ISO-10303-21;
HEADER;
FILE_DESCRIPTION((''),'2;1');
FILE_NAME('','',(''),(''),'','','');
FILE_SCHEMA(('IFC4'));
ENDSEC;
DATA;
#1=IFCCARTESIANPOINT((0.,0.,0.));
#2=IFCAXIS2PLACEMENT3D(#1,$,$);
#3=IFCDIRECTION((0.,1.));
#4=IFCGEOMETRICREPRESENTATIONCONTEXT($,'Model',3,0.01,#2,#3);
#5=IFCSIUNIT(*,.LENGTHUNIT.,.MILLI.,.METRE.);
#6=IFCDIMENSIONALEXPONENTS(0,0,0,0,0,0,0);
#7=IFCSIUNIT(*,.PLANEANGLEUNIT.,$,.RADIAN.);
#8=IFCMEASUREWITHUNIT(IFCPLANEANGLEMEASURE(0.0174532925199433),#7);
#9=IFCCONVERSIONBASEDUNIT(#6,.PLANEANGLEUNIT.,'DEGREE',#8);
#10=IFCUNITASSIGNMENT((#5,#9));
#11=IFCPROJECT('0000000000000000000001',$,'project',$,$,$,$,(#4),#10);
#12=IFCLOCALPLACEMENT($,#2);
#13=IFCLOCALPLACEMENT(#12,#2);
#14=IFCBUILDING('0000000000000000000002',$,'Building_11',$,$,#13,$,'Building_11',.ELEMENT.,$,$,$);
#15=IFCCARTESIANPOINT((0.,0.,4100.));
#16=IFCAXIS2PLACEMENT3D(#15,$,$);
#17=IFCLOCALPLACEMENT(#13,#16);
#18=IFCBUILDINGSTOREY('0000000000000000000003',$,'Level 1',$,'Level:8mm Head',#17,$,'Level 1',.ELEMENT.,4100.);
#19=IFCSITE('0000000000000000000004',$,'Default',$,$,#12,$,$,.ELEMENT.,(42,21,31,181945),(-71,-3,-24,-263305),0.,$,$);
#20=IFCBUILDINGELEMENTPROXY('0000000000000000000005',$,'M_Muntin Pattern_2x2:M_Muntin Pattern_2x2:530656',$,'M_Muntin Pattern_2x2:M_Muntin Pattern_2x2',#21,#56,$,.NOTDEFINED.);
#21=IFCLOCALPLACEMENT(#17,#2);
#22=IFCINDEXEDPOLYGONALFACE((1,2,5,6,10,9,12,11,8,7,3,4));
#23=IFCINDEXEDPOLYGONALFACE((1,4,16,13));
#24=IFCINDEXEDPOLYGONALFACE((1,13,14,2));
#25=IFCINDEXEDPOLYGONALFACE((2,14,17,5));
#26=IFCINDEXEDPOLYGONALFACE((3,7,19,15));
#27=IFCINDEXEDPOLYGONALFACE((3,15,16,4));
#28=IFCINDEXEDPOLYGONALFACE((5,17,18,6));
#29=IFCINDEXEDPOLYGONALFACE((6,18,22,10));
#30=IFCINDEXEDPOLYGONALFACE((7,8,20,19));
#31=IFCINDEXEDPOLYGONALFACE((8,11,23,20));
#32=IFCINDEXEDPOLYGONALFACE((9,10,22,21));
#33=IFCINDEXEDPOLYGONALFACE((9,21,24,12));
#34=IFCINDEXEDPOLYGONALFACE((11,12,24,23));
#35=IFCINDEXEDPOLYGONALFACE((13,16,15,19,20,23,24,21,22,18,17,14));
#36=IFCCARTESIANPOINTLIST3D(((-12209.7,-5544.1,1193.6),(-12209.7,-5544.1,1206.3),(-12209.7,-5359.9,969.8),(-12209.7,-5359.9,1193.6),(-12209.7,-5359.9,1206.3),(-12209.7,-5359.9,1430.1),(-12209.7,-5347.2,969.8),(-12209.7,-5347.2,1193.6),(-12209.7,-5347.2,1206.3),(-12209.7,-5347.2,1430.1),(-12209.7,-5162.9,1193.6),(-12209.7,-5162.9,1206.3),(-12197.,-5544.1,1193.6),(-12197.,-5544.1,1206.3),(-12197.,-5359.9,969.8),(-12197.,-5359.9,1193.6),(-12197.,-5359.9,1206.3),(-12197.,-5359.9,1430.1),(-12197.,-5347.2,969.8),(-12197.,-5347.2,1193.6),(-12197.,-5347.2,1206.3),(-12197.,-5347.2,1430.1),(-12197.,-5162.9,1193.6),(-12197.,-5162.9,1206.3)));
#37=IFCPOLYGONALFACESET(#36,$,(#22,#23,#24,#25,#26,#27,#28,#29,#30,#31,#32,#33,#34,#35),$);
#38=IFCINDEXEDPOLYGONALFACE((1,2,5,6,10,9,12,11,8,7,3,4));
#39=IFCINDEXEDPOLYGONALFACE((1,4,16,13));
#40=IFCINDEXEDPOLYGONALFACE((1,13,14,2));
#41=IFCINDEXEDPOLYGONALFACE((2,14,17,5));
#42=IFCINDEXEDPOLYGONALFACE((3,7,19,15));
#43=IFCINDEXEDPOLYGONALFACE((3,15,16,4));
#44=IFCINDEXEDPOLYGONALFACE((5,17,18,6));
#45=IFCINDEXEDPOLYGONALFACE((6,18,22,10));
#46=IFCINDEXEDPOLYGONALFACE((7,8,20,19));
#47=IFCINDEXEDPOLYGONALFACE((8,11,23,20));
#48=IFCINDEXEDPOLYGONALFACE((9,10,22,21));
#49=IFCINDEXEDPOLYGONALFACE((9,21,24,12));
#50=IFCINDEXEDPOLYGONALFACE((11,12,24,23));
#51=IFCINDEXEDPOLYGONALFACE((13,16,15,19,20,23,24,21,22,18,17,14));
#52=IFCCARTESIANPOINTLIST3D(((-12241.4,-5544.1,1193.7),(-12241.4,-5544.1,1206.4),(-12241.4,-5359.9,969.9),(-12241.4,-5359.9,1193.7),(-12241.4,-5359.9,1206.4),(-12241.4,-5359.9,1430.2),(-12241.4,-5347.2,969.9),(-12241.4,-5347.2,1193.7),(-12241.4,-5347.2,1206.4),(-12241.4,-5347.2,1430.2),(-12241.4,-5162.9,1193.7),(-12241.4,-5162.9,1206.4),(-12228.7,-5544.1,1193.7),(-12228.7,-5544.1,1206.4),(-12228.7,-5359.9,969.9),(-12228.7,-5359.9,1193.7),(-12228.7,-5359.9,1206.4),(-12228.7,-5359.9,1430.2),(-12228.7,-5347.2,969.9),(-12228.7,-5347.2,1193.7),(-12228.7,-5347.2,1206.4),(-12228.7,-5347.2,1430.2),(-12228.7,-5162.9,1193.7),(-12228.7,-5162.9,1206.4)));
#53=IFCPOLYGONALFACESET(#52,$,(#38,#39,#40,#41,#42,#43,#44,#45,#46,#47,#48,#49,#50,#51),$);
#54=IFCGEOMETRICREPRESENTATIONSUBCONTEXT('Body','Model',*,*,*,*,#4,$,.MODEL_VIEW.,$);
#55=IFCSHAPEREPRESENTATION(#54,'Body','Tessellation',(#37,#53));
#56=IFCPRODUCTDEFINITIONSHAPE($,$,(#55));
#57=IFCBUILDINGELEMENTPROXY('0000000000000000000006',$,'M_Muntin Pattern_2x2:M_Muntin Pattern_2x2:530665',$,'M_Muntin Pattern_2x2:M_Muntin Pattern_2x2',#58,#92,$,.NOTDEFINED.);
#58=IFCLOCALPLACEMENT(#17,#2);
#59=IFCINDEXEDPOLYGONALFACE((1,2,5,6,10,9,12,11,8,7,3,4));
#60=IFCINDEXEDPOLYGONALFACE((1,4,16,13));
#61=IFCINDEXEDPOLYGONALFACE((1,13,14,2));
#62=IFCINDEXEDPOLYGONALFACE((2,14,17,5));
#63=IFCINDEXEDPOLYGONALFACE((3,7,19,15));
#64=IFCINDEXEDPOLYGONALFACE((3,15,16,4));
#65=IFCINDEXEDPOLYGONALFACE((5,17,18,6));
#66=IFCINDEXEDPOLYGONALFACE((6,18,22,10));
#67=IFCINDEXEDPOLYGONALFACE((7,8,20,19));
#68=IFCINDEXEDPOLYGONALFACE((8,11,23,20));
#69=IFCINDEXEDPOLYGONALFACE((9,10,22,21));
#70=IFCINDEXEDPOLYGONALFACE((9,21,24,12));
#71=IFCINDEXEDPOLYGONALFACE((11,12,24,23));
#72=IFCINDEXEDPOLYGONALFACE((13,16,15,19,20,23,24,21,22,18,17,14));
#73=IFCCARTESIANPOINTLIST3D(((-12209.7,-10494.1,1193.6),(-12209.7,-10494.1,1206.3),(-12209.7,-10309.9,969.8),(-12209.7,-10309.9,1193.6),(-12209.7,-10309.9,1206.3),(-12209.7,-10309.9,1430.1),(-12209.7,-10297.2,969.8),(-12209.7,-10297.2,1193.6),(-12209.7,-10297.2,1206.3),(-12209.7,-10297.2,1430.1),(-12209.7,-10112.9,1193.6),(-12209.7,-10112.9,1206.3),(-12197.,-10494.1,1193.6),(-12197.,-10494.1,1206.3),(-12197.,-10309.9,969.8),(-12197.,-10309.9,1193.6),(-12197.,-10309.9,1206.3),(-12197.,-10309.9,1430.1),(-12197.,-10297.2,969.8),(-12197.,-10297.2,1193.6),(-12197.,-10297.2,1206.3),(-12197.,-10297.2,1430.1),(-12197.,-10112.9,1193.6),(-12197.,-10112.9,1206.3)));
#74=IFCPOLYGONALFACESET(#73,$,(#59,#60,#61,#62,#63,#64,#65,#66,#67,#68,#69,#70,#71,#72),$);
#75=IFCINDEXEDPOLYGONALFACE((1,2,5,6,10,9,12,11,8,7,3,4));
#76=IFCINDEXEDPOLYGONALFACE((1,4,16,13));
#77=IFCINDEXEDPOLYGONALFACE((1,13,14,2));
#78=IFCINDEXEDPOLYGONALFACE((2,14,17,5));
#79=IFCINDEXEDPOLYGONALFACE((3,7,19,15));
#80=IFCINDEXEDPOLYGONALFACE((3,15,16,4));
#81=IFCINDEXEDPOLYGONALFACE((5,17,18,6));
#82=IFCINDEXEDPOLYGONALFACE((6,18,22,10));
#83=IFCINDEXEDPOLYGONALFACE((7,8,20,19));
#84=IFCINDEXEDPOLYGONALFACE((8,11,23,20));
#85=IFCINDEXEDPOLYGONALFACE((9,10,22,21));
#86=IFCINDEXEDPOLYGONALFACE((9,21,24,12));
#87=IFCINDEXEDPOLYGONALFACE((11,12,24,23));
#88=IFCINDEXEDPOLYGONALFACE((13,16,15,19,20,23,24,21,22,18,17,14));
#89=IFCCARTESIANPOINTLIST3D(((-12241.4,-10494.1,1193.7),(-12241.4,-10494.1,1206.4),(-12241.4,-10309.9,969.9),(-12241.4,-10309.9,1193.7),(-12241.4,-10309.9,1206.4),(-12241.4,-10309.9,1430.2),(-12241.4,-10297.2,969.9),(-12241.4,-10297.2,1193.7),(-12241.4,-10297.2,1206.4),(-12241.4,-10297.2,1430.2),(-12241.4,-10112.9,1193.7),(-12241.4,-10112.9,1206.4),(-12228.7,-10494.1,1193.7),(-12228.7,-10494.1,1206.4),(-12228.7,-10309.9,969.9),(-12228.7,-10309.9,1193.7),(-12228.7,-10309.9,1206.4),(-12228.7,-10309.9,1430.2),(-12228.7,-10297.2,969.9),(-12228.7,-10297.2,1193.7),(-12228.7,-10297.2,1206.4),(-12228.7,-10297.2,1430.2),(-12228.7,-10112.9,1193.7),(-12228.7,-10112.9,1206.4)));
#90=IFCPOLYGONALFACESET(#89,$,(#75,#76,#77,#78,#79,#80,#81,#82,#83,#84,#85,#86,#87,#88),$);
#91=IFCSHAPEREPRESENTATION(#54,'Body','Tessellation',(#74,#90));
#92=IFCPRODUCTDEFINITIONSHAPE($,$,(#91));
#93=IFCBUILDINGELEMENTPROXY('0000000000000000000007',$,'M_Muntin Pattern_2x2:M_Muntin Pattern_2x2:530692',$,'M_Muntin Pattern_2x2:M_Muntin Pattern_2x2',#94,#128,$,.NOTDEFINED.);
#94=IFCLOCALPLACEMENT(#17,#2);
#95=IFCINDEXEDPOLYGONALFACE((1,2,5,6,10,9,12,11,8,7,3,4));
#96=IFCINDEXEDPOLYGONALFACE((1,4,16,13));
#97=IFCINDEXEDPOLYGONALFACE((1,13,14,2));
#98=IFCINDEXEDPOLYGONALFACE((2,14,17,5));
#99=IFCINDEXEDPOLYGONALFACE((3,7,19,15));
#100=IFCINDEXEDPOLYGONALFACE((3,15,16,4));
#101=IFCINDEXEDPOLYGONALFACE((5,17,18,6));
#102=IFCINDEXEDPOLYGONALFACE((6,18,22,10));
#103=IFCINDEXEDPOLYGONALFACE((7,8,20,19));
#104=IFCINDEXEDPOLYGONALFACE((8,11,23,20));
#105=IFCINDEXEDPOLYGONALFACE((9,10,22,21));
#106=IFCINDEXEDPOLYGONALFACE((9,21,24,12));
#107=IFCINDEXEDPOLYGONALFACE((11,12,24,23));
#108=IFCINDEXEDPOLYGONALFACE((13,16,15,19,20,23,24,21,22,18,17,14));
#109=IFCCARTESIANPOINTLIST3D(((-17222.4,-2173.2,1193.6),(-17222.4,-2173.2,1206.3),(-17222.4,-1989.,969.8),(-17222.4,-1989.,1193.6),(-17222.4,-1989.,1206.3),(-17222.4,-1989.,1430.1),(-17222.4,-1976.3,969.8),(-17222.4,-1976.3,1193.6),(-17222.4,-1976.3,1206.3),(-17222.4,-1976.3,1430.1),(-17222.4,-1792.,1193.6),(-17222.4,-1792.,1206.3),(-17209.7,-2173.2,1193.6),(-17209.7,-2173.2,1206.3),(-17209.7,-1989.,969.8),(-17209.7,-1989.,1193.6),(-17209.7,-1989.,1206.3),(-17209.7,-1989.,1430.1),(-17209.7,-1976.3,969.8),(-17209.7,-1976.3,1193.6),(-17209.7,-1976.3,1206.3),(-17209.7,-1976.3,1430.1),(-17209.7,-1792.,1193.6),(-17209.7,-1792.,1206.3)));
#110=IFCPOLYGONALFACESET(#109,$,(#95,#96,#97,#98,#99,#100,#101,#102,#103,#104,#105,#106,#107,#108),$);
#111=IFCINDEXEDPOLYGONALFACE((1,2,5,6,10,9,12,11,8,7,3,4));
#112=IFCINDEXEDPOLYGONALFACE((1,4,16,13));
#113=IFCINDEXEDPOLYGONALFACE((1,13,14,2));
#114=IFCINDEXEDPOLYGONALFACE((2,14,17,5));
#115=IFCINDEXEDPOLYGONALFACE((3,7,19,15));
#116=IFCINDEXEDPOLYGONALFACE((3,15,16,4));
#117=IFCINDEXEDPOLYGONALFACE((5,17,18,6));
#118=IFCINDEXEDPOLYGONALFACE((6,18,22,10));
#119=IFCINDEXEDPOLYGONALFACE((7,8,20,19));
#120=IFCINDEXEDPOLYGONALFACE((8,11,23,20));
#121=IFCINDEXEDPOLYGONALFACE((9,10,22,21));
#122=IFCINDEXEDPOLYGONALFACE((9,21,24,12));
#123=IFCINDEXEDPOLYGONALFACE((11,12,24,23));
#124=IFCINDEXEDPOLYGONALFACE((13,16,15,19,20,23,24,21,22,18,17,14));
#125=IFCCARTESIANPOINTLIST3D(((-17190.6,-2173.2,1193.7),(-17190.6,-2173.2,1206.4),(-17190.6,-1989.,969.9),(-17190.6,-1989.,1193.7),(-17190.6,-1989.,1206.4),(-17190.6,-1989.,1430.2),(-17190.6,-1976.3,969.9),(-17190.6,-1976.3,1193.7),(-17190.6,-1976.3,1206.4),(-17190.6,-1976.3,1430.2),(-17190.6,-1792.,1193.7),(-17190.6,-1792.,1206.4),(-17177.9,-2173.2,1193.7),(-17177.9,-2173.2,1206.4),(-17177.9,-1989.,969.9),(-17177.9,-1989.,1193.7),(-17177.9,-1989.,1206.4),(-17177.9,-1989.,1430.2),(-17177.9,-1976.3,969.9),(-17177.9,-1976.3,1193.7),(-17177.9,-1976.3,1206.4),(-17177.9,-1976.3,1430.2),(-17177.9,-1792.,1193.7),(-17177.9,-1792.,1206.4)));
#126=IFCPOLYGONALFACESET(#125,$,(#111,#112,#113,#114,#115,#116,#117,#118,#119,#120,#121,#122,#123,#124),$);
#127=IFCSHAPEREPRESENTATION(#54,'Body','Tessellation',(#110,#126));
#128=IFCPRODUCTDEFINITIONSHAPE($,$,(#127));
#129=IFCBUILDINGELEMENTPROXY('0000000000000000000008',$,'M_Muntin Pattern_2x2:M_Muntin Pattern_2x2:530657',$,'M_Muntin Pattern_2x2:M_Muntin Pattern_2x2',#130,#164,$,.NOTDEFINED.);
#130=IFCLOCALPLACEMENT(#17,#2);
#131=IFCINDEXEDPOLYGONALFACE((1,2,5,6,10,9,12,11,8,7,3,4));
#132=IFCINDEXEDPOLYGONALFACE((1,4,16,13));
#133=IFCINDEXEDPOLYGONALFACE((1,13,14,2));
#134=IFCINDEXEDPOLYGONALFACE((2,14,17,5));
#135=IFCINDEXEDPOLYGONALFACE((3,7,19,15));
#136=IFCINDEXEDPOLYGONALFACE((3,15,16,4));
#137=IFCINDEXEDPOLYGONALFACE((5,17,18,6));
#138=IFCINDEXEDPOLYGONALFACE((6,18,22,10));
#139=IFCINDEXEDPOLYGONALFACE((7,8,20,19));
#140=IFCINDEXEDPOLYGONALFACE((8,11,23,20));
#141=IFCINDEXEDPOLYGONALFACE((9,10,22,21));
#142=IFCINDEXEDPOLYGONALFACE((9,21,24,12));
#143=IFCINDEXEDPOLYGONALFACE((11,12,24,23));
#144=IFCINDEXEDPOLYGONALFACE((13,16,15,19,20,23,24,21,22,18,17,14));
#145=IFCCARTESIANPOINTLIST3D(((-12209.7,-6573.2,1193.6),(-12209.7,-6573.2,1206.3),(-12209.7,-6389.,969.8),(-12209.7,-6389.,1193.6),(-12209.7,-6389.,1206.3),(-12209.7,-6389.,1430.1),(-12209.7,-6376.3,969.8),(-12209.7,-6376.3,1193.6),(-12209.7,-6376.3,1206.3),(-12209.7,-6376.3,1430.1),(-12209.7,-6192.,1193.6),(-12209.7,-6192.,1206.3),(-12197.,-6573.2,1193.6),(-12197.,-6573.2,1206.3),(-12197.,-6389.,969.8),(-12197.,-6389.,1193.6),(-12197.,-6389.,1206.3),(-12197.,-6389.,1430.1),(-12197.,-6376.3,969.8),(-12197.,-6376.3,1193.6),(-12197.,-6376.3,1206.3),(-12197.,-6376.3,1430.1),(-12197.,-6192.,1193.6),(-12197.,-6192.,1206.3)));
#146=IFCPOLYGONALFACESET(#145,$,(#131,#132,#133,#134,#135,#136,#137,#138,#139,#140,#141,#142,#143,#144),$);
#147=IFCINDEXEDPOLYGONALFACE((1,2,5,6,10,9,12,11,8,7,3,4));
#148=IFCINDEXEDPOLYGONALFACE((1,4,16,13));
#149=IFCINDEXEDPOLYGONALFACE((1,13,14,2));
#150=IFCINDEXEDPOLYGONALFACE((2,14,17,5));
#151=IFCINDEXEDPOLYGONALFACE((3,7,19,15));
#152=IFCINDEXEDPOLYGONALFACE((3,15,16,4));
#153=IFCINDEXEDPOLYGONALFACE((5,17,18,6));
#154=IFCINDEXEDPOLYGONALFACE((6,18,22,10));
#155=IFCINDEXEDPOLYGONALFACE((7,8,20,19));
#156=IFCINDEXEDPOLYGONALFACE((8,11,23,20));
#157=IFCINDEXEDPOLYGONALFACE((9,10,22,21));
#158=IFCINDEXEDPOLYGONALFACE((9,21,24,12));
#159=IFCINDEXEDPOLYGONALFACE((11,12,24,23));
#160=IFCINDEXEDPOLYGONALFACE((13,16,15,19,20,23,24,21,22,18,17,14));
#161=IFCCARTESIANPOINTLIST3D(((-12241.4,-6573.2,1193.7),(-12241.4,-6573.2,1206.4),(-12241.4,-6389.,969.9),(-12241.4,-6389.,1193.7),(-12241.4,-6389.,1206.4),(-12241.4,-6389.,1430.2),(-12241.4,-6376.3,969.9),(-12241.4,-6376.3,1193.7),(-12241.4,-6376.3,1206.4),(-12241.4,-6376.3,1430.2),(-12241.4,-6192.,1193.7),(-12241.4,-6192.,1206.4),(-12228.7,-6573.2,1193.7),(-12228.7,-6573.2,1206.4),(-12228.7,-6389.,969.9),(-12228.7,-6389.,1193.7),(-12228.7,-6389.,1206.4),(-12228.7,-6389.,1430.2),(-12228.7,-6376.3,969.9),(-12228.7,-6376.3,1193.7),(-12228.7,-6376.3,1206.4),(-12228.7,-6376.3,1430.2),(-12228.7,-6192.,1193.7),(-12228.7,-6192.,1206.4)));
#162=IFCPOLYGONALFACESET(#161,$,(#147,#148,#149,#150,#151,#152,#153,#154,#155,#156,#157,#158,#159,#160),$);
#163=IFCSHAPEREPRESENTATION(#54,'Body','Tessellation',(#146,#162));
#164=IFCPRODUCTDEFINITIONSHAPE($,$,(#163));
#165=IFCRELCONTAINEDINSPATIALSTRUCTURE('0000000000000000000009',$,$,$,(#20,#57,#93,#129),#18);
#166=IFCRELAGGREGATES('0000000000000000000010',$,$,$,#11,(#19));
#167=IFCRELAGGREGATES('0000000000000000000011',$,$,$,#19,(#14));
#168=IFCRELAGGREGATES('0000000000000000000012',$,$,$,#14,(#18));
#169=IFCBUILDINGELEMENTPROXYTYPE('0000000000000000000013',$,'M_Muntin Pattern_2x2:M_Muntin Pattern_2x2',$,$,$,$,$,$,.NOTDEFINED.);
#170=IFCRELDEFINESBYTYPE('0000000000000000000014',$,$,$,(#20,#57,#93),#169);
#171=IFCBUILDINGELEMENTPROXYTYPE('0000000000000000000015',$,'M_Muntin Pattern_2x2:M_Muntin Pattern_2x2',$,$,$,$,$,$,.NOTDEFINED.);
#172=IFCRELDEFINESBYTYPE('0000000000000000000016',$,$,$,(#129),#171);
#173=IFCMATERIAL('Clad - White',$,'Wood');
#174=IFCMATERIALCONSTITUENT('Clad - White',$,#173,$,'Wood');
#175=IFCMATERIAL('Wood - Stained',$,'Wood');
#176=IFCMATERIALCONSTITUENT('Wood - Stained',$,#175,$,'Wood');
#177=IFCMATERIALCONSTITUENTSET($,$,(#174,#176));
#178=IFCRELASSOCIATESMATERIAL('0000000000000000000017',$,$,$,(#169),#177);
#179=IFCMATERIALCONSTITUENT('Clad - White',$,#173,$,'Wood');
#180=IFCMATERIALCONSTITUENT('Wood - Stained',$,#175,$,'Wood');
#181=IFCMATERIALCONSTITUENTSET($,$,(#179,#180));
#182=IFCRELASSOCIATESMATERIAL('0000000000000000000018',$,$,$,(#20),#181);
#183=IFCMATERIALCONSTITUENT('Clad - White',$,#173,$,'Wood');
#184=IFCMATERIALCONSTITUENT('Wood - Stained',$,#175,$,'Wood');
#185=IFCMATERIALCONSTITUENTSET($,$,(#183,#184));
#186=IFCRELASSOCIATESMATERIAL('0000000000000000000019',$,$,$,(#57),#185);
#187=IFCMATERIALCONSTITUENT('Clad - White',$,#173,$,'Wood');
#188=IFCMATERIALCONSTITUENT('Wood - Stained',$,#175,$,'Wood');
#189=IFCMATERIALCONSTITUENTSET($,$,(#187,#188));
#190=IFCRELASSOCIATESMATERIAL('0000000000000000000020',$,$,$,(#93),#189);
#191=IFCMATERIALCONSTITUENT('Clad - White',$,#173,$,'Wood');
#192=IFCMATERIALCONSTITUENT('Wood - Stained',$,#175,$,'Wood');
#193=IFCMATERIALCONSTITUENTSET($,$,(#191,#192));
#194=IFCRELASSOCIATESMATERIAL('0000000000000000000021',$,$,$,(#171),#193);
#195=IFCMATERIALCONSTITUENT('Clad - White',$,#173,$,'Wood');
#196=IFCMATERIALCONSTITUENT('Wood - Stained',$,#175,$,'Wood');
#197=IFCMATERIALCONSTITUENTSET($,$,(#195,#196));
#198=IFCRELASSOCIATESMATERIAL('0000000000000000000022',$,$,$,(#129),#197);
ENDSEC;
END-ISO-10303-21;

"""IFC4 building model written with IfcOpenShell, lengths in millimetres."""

from ifc_helpers import new_model, entity, si_unit, converted_unit, direction, frame, origin, place, context, subcontext, project, spatial, indexed_curve, outline, extrude, source, transform, mapped, material, constituent, constituent_set, type_object, type_shapes, element, save


model = new_model("IFC4")

# Units and contexts
model_context = context("Model", 3, precision=0.01, world=origin(), true_north=direction((0.0, 1.0)))
body_context = subcontext(model_context, "Body", "Model", "MODEL_VIEW")
ifc_project = project(units=[si_unit("LENGTHUNIT", "METRE", prefix="MILLI"), converted_unit("PLANEANGLEUNIT", "DEGREE", entity("IfcPlaneAngleMeasure", 0.0174532925199433), si_unit("PLANEANGLEUNIT", "RADIAN"), dimensions=[0, 0, 0, 0, 0, 0, 0])], contexts=[model_context])

# Site, building, storey
site_placement = place(None, origin())
site = spatial("IfcSite", under=ifc_project, at=site_placement, Name="Default", CompositionType="ELEMENT", RefLatitude=(42, 21, 31, 181945), RefLongitude=(-71, -3, -24, -263305), RefElevation=0.0)
building_placement = place(site_placement, origin())
building = spatial("IfcBuilding", under=site, at=building_placement, Name="Building_11", LongName="Building_11", CompositionType="ELEMENT")
storey_placement = place(building_placement, frame((0.0, 0.0, 4100.0)))
storey = spatial("IfcBuildingStorey", under=building, at=storey_placement, Name="Level 1", ObjectType="Level:8mm Head", LongName="Level 1", CompositionType="ELEMENT", Elevation=4100.0)

# Building element proxies
ifc_material_1 = material(Name="Clad - White", Category="Wood")
ifc_constituent_1 = constituent(ifc_material_1, Name="Clad - White", Category="Wood")
ifc_material_2 = material(Name="Wood - Stained", Category="Wood")
ifc_constituent_2 = constituent(ifc_material_2, Name="Wood - Stained", Category="Wood")
ifc_constituent_set_1 = constituent_set(constituents=[ifc_constituent_1, ifc_constituent_2])
ifc_constituent_3 = constituent(ifc_material_1, Name="Clad - White", Category="Wood")
ifc_constituent_4 = constituent(ifc_material_2, Name="Wood - Stained", Category="Wood")
ifc_constituent_set_2 = constituent_set(constituents=[ifc_constituent_3, ifc_constituent_4])
building_element_proxy_type_1 = type_object("IfcBuildingElementProxyType", Name="M_Muntin Pattern_2x2:M_Muntin Pattern_2x2", PredefinedType="NOTDEFINED", material=ifc_constituent_set_2)
shared_shape_1 = source(origin(), body_context, "Body", "SweptSolid", [
    extrude(outline(indexed_curve([(6.4, -6.4), (230.1, -6.4), (230.1, 6.3), (6.4, 6.3), (6.4, 190.6), (-6.3, 190.6), (-6.3, 6.3), (-230.2, 6.3), (-230.2, -6.4), (-6.3, -6.4), (-6.3, -190.6), (6.4, -190.6), (6.4, -6.4)], self_intersect=False)), frame((0.0, 9.5, 230.1), z_axis=(0.0, 1.0, 0.0), x_axis=(0.0, 0.0, 1.0)), (0.0, 0.0, 1.0), 12.7),
    extrude(outline(indexed_curve([(6.4, -6.4), (230.2, -6.4), (230.2, 6.3), (6.4, 6.3), (6.4, 190.6), (-6.3, 190.6), (-6.3, 6.3), (-230.2, 6.3), (-230.2, -6.4), (-6.3, -6.4), (-6.3, -190.6), (6.4, -190.6), (6.4, -6.4)], self_intersect=False)), frame((0.0, -22.2, 230.2), z_axis=(0.0, 1.0, 0.0), x_axis=(0.0, 0.0, 1.0)), (0.0, 0.0, 1.0), 12.7),
])
type_shapes(building_element_proxy_type_1, [shared_shape_1])
proxy_1_placement = place(storey_placement, frame((-12219.2, -5353.5, 969.9), z_axis=(0.0, 0.0, 1.0), x_axis=(0.0, -1.0, 0.0)))
element("IfcBuildingElementProxy", 1, at=proxy_1_placement, inside=storey, type_object=building_element_proxy_type_1, material=ifc_constituent_set_1, Name="M_Muntin Pattern_2x2:M_Muntin Pattern_2x2:530656", ObjectType="M_Muntin Pattern_2x2:M_Muntin Pattern_2x2", PredefinedType="NOTDEFINED", context=body_context, shape_type="MappedRepresentation", body=[
    mapped(shared_shape_1, transform((0.0, 0.0, 0.0), scale=1.0)),
])
ifc_constituent_5 = constituent(ifc_material_1, Name="Clad - White", Category="Wood")
ifc_constituent_6 = constituent(ifc_material_2, Name="Wood - Stained", Category="Wood")
ifc_constituent_set_3 = constituent_set(constituents=[ifc_constituent_5, ifc_constituent_6])
proxy_2_placement = place(storey_placement, frame((-12219.2, -10303.5, 969.9), z_axis=(0.0, 0.0, 1.0), x_axis=(0.0, -1.0, 0.0)))
element("IfcBuildingElementProxy", 2, at=proxy_2_placement, inside=storey, type_object=building_element_proxy_type_1, material=ifc_constituent_set_3, Name="M_Muntin Pattern_2x2:M_Muntin Pattern_2x2:530665", ObjectType="M_Muntin Pattern_2x2:M_Muntin Pattern_2x2", PredefinedType="NOTDEFINED", context=body_context, shape_type="MappedRepresentation", body=[
    mapped(shared_shape_1, transform((0.0, 0.0, 0.0), scale=1.0)),
])
ifc_constituent_7 = constituent(ifc_material_1, Name="Clad - White", Category="Wood")
ifc_constituent_8 = constituent(ifc_material_2, Name="Wood - Stained", Category="Wood")
ifc_constituent_set_4 = constituent_set(constituents=[ifc_constituent_7, ifc_constituent_8])
proxy_3_placement = place(storey_placement, frame((-17200.2, -1982.6, 969.9), z_axis=(0.0, 0.0, 1.0), x_axis=(0.0, 1.0, 0.0)))
element("IfcBuildingElementProxy", 3, at=proxy_3_placement, inside=storey, type_object=building_element_proxy_type_1, material=ifc_constituent_set_4, Name="M_Muntin Pattern_2x2:M_Muntin Pattern_2x2:530692", ObjectType="M_Muntin Pattern_2x2:M_Muntin Pattern_2x2", PredefinedType="NOTDEFINED", context=body_context, shape_type="MappedRepresentation", body=[
    mapped(shared_shape_1, transform((0.0, 0.0, 0.0), scale=1.0)),
])
ifc_constituent_9 = constituent(ifc_material_1, Name="Clad - White", Category="Wood")
ifc_constituent_10 = constituent(ifc_material_2, Name="Wood - Stained", Category="Wood")
ifc_constituent_set_5 = constituent_set(constituents=[ifc_constituent_9, ifc_constituent_10])
ifc_constituent_11 = constituent(ifc_material_1, Name="Clad - White", Category="Wood")
ifc_constituent_12 = constituent(ifc_material_2, Name="Wood - Stained", Category="Wood")
ifc_constituent_set_6 = constituent_set(constituents=[ifc_constituent_11, ifc_constituent_12])
building_element_proxy_type_2 = type_object("IfcBuildingElementProxyType", Name="M_Muntin Pattern_2x2:M_Muntin Pattern_2x2", PredefinedType="NOTDEFINED", material=ifc_constituent_set_6)
shared_shape_2 = source(origin(), body_context, "Body", "SweptSolid", [
    extrude(outline(indexed_curve([(6.4, -6.4), (230.1, -6.4), (230.1, 6.3), (6.4, 6.3), (6.4, 190.6), (-6.3, 190.6), (-6.3, 6.3), (-230.2, 6.3), (-230.2, -6.4), (-6.3, -6.4), (-6.3, -190.6), (6.4, -190.6), (6.4, -6.4)], self_intersect=False)), frame((0.0, -22.2, 230.1), z_axis=(0.0, 1.0, 0.0), x_axis=(0.0, 0.0, 1.0)), (0.0, 0.0, 1.0), 12.7),
    extrude(outline(indexed_curve([(6.4, -6.4), (230.2, -6.4), (230.2, 6.3), (6.4, 6.3), (6.4, 190.6), (-6.3, 190.6), (-6.3, 6.3), (-230.2, 6.3), (-230.2, -6.4), (-6.3, -6.4), (-6.3, -190.6), (6.4, -190.6), (6.4, -6.4)], self_intersect=False)), frame((0.0, 9.5, 230.2), z_axis=(0.0, 1.0, 0.0), x_axis=(0.0, 0.0, 1.0)), (0.0, 0.0, 1.0), 12.7),
])
type_shapes(building_element_proxy_type_2, [shared_shape_2])
proxy_4_placement = place(storey_placement, frame((-12219.2, -6382.6, 969.9), z_axis=(0.0, 0.0, 1.0), x_axis=(0.0, 1.0, 0.0)))
element("IfcBuildingElementProxy", 4, at=proxy_4_placement, inside=storey, type_object=building_element_proxy_type_2, material=ifc_constituent_set_5, Name="M_Muntin Pattern_2x2:M_Muntin Pattern_2x2:530657", ObjectType="M_Muntin Pattern_2x2:M_Muntin Pattern_2x2", PredefinedType="NOTDEFINED", context=body_context, shape_type="MappedRepresentation", body=[
    mapped(shared_shape_2, transform((0.0, 0.0, 0.0), scale=1.0)),
])

save(model, "model.ifc")
